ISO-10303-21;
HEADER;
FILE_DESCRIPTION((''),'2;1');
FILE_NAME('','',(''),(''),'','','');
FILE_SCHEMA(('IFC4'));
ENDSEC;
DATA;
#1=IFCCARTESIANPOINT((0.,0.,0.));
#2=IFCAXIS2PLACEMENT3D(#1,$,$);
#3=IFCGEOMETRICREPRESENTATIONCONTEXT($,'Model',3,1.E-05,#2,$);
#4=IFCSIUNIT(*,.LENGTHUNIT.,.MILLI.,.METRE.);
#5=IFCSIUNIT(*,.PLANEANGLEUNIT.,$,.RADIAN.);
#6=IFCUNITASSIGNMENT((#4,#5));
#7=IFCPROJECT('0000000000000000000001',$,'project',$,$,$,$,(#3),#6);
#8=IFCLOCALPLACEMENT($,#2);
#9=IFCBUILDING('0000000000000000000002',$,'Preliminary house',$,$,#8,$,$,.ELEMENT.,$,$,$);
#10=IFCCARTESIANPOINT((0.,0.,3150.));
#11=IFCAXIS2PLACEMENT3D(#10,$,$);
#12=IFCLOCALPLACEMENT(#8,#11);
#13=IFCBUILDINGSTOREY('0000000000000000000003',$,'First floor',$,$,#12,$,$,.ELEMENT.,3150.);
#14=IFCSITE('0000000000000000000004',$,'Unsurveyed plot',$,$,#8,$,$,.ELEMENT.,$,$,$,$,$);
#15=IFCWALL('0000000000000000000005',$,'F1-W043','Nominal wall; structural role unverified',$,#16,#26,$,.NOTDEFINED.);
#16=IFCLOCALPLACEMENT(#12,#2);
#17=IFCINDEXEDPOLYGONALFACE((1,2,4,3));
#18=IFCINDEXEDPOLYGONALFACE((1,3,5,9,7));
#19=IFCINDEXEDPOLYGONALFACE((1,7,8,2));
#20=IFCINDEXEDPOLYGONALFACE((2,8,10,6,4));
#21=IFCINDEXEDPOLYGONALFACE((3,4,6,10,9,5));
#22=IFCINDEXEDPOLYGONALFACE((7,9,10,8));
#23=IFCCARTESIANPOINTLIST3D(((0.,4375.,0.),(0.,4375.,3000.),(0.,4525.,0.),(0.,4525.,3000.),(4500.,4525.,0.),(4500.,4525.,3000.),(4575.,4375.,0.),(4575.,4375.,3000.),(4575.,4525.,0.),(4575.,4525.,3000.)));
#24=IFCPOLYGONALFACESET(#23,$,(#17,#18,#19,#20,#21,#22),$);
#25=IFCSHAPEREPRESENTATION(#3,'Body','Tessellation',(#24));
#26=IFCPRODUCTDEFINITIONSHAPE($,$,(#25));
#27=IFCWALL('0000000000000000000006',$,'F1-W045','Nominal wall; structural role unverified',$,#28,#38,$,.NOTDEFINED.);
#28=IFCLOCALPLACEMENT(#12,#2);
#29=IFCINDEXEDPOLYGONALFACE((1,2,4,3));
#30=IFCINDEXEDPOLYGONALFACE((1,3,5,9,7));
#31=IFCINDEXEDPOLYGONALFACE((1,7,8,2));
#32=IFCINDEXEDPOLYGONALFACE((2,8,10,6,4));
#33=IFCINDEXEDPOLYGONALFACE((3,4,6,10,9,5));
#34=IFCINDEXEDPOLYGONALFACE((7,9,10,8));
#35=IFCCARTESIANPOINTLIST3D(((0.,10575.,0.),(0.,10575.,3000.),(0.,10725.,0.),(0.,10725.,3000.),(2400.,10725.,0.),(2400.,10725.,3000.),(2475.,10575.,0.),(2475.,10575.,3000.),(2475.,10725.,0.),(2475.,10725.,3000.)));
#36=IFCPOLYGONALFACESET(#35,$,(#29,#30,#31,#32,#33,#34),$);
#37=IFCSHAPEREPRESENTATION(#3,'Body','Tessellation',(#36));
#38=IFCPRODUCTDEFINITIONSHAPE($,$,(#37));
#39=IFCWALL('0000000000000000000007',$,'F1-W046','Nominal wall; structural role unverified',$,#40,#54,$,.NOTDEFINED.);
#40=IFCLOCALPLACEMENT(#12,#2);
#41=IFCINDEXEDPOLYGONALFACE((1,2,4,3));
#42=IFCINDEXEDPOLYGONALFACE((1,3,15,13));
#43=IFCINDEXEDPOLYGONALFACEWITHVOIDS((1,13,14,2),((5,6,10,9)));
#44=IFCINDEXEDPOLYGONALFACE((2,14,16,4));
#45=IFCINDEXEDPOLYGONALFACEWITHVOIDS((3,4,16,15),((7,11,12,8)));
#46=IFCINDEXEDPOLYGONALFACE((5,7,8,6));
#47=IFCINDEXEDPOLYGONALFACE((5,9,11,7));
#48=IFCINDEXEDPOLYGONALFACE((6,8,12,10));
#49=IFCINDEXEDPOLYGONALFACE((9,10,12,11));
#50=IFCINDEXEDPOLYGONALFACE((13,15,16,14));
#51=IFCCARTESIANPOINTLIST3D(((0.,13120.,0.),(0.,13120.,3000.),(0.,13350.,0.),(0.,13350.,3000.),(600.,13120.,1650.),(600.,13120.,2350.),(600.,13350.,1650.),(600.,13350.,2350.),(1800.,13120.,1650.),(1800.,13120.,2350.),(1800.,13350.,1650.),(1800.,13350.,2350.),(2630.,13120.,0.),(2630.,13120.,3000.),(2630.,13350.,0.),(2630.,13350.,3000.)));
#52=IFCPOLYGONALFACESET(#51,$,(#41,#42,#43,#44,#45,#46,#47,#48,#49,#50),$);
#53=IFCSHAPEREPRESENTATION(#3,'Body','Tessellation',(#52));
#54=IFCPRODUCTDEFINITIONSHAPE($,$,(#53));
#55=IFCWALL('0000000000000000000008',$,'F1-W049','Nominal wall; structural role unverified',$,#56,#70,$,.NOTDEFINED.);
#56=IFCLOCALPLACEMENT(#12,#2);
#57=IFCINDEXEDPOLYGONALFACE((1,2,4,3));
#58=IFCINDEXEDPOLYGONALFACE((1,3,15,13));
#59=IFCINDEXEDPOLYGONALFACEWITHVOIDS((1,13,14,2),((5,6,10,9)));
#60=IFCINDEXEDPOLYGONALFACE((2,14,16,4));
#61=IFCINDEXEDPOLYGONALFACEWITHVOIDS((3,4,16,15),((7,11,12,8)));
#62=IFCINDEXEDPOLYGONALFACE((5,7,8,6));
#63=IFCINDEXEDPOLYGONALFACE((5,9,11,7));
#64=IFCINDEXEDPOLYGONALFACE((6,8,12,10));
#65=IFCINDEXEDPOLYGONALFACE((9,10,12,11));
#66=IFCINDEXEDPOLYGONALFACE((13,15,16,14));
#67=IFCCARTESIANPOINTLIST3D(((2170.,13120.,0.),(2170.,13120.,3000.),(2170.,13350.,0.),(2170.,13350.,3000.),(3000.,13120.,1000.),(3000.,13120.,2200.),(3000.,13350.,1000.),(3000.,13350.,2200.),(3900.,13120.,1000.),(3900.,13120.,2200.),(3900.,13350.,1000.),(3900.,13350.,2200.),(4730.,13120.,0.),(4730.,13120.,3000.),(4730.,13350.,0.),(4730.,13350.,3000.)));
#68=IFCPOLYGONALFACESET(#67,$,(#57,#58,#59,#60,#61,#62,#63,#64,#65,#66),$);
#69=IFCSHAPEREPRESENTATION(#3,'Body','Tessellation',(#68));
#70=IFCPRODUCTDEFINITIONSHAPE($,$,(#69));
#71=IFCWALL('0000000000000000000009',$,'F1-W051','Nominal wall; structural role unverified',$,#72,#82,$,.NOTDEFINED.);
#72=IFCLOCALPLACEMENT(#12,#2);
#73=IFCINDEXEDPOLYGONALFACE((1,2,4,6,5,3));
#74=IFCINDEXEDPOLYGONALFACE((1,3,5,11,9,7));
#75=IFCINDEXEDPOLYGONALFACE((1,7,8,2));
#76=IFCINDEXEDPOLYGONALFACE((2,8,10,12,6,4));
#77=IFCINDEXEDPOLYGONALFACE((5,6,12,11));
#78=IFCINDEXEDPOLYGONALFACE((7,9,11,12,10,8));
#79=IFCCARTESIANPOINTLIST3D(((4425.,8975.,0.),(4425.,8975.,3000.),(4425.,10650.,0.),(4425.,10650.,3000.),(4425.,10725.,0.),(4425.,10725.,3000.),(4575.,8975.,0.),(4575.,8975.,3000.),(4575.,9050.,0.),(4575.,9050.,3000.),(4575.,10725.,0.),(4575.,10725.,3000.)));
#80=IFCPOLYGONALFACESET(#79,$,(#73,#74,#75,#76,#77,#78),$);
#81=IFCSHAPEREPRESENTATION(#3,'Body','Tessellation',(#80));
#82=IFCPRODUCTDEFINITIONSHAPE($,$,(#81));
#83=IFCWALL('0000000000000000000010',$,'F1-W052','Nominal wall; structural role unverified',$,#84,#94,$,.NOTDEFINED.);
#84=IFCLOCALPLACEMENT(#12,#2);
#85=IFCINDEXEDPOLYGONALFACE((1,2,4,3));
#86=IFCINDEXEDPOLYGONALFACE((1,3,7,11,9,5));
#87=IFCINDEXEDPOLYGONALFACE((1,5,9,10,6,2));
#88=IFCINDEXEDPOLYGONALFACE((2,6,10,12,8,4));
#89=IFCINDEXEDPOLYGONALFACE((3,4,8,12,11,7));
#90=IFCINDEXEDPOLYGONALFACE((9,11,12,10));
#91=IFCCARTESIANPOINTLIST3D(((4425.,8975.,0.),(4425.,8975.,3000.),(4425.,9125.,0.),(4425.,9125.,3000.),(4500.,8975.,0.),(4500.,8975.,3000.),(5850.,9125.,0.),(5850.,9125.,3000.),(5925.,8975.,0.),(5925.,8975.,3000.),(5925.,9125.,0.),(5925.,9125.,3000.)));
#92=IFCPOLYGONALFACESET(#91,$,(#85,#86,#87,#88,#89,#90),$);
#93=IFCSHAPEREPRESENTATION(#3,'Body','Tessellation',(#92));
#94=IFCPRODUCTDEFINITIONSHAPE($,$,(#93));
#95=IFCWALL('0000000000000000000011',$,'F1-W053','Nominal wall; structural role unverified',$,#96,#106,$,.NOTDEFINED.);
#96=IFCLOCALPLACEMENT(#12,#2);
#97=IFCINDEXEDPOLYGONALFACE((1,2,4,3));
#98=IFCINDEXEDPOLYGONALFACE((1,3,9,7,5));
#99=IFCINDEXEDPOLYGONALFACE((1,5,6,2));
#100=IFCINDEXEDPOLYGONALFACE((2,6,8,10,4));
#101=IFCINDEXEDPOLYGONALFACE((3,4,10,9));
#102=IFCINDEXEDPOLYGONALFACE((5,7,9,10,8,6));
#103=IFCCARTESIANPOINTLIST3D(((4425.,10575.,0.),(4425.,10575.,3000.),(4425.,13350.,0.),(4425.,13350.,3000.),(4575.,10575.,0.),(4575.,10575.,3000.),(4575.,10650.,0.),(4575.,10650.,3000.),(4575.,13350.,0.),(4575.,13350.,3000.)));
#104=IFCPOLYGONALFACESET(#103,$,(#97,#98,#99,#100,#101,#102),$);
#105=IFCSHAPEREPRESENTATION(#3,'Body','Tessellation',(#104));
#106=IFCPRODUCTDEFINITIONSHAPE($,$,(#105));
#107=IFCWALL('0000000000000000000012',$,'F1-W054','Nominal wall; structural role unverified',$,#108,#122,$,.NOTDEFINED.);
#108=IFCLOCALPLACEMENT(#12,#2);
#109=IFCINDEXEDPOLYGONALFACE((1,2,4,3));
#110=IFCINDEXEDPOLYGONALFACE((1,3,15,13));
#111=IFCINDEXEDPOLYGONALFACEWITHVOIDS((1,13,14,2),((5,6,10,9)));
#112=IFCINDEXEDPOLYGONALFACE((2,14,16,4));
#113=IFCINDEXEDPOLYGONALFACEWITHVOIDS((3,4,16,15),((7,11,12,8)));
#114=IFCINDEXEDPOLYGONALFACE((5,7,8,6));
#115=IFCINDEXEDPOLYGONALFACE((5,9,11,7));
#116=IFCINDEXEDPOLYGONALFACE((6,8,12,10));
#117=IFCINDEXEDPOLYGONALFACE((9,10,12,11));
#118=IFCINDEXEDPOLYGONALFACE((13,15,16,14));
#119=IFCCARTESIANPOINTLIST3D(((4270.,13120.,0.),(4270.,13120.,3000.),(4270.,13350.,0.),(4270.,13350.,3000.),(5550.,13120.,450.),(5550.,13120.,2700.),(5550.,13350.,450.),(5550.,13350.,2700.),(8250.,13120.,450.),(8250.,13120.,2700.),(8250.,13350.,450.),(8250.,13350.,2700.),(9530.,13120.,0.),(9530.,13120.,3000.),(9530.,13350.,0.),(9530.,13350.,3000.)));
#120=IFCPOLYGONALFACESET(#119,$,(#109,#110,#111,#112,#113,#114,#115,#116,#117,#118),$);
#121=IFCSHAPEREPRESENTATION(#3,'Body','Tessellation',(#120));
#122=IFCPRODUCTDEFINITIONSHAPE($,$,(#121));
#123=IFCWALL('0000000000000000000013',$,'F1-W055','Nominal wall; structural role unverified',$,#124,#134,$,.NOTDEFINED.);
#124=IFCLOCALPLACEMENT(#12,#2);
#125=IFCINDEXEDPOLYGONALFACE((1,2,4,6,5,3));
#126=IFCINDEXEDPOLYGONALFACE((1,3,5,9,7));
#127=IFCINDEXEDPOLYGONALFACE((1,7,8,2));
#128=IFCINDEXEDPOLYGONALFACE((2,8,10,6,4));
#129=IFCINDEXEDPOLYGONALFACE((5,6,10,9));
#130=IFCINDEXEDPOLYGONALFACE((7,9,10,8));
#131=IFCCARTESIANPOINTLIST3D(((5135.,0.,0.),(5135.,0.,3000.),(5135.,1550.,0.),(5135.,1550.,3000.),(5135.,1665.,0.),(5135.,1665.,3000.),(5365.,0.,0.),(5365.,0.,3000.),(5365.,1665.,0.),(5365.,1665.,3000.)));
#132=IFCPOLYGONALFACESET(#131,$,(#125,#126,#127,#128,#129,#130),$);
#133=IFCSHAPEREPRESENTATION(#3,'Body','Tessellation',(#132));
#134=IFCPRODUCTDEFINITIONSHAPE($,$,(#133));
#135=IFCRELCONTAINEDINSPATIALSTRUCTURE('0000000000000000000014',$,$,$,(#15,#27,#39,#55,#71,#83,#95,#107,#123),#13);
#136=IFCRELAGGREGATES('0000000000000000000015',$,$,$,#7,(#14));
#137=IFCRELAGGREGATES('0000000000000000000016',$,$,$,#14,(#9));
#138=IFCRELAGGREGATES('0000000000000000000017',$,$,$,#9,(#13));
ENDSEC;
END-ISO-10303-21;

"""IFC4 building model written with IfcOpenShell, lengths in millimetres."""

from ifc_helpers import new_model, si_unit, frame, origin, place, context, project, spatial, polyline, outline, extrude, element, save


model = new_model("IFC4")

# Units and contexts
model_context = context("Model", 3, precision=1e-05, world=origin())
ifc_project = project(units=[si_unit("LENGTHUNIT", "METRE", prefix="MILLI"), si_unit("PLANEANGLEUNIT", "RADIAN")], contexts=[model_context])

# Site, building, storey
placement_1 = place(None, origin())
site = spatial("IfcSite", under=ifc_project, at=placement_1, Name="Unsurveyed plot", CompositionType="ELEMENT")
building = spatial("IfcBuilding", under=site, at=placement_1, Name="Preliminary house", CompositionType="ELEMENT")
placement_2 = place(placement_1, frame((0.0, 0.0, 3150.0)))
storey = spatial("IfcBuildingStorey", under=building, at=placement_2, Name="First floor", CompositionType="ELEMENT", Elevation=3150.0)

# Wall
element("IfcWall", 1, at=placement_2, inside=storey, Name="F1-W043", Description="Nominal wall; structural role unverified", PredefinedType="NOTDEFINED", context=model_context, shape_type="SweptSolid", body=[
    extrude(outline(polyline([(4575.0, 4525.0), (4575.0, 4375.0), (0.0, 4375.0), (0.0, 4525.0), (4500.0, 4525.0), (4575.0, 4525.0)])), origin(), (0.0, 0.0, 1.0), 3000.0),
])

# Wall
element("IfcWall", 2, at=placement_2, inside=storey, Name="F1-W045", Description="Nominal wall; structural role unverified", PredefinedType="NOTDEFINED", context=model_context, shape_type="SweptSolid", body=[
    extrude(outline(polyline([(2475.0, 10725.0), (2475.0, 10575.0), (0.0, 10575.0), (0.0, 10725.0), (2400.0, 10725.0), (2475.0, 10725.0)])), origin(), (0.0, 0.0, 1.0), 3000.0),
])

# Walls, openings
wall_1 = element("IfcWall", 3, at=placement_2, inside=storey, Name="F1-W046", Description="Nominal wall; structural role unverified", PredefinedType="NOTDEFINED", context=model_context, shape_type="SweptSolid", body=[
    extrude(outline(polyline([(2630.0, 13120.0), (0.0, 13120.0), (0.0, 13350.0), (2630.0, 13350.0), (2630.0, 13120.0)])), origin(), (0.0, 0.0, 1.0), 3000.0),
])
element("IfcOpeningElement", 4, at=placement_2, cuts=wall_1, PredefinedType="OPENING", context=model_context, shape_type="SweptSolid", body=[
    extrude(outline(polyline([(600.0, 12705.0), (1800.0, 12705.0), (1800.0, 13765.0), (600.0, 13765.0), (600.0, 12705.0)])), frame((0.0, 0.0, 1650.0)), (0.0, 0.0, 1.0), 700.0),
])
wall_2 = element("IfcWall", 5, at=placement_2, inside=storey, Name="F1-W049", Description="Nominal wall; structural role unverified", PredefinedType="NOTDEFINED", context=model_context, shape_type="SweptSolid", body=[
    extrude(outline(polyline([(4730.0, 13120.0), (2400.0, 13120.0), (2170.0, 13120.0), (2170.0, 13350.0), (4730.0, 13350.0), (4730.0, 13120.0)])), origin(), (0.0, 0.0, 1.0), 3000.0),
])
element("IfcOpeningElement", 6, at=placement_2, cuts=wall_2, PredefinedType="OPENING", context=model_context, shape_type="SweptSolid", body=[
    extrude(outline(polyline([(3000.0, 12705.0), (3900.0, 12705.0), (3900.0, 13765.0), (3000.0, 13765.0), (3000.0, 12705.0)])), frame((0.0, 0.0, 1000.0)), (0.0, 0.0, 1.0), 1200.0),
])

# Walls
element("IfcWall", 7, at=placement_2, inside=storey, Name="F1-W051", Description="Nominal wall; structural role unverified", PredefinedType="NOTDEFINED", context=model_context, shape_type="SweptSolid", body=[
    extrude(outline(polyline([(4425.0, 10725.0), (4575.0, 10725.0), (4575.0, 9050.0), (4575.0, 8975.0), (4425.0, 8975.0), (4425.0, 10650.0), (4425.0, 10725.0)])), origin(), (0.0, 0.0, 1.0), 3000.0),
])
element("IfcWall", 8, at=placement_2, inside=storey, Name="F1-W052", Description="Nominal wall; structural role unverified", PredefinedType="NOTDEFINED", context=model_context, shape_type="SweptSolid", body=[
    extrude(outline(polyline([(5925.0, 9125.0), (5925.0, 8975.0), (4500.0, 8975.0), (4425.0, 8975.0), (4425.0, 9125.0), (5850.0, 9125.0), (5925.0, 9125.0)])), origin(), (0.0, 0.0, 1.0), 3000.0),
])
element("IfcWall", 9, at=placement_2, inside=storey, Name="F1-W053", Description="Nominal wall; structural role unverified", PredefinedType="NOTDEFINED", context=model_context, shape_type="SweptSolid", body=[
    extrude(outline(polyline([(4575.0, 10650.0), (4575.0, 10575.0), (4425.0, 10575.0), (4425.0, 13350.0), (4575.0, 13350.0), (4575.0, 10650.0)])), origin(), (0.0, 0.0, 1.0), 3000.0),
])

# Wall, opening
wall_3 = element("IfcWall", 10, at=placement_2, inside=storey, Name="F1-W054", Description="Nominal wall; structural role unverified", PredefinedType="NOTDEFINED", context=model_context, shape_type="SweptSolid", body=[
    extrude(outline(polyline([(9530.0, 13120.0), (4500.0, 13120.0), (4270.0, 13120.0), (4270.0, 13350.0), (9530.0, 13350.0), (9530.0, 13120.0)])), origin(), (0.0, 0.0, 1.0), 3000.0),
])
element("IfcOpeningElement", 11, at=placement_2, cuts=wall_3, PredefinedType="OPENING", context=model_context, shape_type="SweptSolid", body=[
    extrude(outline(polyline([(5550.0, 12705.0), (8250.0, 12705.0), (8250.0, 13765.0), (5550.0, 13765.0), (5550.0, 12705.0)])), frame((0.0, 0.0, 450.0)), (0.0, 0.0, 1.0), 2250.0),
])

# Wall
element("IfcWall", 12, at=placement_2, inside=storey, Name="F1-W055", Description="Nominal wall; structural role unverified", PredefinedType="NOTDEFINED", context=model_context, shape_type="SweptSolid", body=[
    extrude(outline(polyline([(5135.0, 1665.0), (5365.0, 1665.0), (5365.0, 0.0), (5135.0, 0.0), (5135.0, 1550.0), (5135.0, 1665.0)])), origin(), (0.0, 0.0, 1.0), 3000.0),
])

save(model, "model.ifc")
